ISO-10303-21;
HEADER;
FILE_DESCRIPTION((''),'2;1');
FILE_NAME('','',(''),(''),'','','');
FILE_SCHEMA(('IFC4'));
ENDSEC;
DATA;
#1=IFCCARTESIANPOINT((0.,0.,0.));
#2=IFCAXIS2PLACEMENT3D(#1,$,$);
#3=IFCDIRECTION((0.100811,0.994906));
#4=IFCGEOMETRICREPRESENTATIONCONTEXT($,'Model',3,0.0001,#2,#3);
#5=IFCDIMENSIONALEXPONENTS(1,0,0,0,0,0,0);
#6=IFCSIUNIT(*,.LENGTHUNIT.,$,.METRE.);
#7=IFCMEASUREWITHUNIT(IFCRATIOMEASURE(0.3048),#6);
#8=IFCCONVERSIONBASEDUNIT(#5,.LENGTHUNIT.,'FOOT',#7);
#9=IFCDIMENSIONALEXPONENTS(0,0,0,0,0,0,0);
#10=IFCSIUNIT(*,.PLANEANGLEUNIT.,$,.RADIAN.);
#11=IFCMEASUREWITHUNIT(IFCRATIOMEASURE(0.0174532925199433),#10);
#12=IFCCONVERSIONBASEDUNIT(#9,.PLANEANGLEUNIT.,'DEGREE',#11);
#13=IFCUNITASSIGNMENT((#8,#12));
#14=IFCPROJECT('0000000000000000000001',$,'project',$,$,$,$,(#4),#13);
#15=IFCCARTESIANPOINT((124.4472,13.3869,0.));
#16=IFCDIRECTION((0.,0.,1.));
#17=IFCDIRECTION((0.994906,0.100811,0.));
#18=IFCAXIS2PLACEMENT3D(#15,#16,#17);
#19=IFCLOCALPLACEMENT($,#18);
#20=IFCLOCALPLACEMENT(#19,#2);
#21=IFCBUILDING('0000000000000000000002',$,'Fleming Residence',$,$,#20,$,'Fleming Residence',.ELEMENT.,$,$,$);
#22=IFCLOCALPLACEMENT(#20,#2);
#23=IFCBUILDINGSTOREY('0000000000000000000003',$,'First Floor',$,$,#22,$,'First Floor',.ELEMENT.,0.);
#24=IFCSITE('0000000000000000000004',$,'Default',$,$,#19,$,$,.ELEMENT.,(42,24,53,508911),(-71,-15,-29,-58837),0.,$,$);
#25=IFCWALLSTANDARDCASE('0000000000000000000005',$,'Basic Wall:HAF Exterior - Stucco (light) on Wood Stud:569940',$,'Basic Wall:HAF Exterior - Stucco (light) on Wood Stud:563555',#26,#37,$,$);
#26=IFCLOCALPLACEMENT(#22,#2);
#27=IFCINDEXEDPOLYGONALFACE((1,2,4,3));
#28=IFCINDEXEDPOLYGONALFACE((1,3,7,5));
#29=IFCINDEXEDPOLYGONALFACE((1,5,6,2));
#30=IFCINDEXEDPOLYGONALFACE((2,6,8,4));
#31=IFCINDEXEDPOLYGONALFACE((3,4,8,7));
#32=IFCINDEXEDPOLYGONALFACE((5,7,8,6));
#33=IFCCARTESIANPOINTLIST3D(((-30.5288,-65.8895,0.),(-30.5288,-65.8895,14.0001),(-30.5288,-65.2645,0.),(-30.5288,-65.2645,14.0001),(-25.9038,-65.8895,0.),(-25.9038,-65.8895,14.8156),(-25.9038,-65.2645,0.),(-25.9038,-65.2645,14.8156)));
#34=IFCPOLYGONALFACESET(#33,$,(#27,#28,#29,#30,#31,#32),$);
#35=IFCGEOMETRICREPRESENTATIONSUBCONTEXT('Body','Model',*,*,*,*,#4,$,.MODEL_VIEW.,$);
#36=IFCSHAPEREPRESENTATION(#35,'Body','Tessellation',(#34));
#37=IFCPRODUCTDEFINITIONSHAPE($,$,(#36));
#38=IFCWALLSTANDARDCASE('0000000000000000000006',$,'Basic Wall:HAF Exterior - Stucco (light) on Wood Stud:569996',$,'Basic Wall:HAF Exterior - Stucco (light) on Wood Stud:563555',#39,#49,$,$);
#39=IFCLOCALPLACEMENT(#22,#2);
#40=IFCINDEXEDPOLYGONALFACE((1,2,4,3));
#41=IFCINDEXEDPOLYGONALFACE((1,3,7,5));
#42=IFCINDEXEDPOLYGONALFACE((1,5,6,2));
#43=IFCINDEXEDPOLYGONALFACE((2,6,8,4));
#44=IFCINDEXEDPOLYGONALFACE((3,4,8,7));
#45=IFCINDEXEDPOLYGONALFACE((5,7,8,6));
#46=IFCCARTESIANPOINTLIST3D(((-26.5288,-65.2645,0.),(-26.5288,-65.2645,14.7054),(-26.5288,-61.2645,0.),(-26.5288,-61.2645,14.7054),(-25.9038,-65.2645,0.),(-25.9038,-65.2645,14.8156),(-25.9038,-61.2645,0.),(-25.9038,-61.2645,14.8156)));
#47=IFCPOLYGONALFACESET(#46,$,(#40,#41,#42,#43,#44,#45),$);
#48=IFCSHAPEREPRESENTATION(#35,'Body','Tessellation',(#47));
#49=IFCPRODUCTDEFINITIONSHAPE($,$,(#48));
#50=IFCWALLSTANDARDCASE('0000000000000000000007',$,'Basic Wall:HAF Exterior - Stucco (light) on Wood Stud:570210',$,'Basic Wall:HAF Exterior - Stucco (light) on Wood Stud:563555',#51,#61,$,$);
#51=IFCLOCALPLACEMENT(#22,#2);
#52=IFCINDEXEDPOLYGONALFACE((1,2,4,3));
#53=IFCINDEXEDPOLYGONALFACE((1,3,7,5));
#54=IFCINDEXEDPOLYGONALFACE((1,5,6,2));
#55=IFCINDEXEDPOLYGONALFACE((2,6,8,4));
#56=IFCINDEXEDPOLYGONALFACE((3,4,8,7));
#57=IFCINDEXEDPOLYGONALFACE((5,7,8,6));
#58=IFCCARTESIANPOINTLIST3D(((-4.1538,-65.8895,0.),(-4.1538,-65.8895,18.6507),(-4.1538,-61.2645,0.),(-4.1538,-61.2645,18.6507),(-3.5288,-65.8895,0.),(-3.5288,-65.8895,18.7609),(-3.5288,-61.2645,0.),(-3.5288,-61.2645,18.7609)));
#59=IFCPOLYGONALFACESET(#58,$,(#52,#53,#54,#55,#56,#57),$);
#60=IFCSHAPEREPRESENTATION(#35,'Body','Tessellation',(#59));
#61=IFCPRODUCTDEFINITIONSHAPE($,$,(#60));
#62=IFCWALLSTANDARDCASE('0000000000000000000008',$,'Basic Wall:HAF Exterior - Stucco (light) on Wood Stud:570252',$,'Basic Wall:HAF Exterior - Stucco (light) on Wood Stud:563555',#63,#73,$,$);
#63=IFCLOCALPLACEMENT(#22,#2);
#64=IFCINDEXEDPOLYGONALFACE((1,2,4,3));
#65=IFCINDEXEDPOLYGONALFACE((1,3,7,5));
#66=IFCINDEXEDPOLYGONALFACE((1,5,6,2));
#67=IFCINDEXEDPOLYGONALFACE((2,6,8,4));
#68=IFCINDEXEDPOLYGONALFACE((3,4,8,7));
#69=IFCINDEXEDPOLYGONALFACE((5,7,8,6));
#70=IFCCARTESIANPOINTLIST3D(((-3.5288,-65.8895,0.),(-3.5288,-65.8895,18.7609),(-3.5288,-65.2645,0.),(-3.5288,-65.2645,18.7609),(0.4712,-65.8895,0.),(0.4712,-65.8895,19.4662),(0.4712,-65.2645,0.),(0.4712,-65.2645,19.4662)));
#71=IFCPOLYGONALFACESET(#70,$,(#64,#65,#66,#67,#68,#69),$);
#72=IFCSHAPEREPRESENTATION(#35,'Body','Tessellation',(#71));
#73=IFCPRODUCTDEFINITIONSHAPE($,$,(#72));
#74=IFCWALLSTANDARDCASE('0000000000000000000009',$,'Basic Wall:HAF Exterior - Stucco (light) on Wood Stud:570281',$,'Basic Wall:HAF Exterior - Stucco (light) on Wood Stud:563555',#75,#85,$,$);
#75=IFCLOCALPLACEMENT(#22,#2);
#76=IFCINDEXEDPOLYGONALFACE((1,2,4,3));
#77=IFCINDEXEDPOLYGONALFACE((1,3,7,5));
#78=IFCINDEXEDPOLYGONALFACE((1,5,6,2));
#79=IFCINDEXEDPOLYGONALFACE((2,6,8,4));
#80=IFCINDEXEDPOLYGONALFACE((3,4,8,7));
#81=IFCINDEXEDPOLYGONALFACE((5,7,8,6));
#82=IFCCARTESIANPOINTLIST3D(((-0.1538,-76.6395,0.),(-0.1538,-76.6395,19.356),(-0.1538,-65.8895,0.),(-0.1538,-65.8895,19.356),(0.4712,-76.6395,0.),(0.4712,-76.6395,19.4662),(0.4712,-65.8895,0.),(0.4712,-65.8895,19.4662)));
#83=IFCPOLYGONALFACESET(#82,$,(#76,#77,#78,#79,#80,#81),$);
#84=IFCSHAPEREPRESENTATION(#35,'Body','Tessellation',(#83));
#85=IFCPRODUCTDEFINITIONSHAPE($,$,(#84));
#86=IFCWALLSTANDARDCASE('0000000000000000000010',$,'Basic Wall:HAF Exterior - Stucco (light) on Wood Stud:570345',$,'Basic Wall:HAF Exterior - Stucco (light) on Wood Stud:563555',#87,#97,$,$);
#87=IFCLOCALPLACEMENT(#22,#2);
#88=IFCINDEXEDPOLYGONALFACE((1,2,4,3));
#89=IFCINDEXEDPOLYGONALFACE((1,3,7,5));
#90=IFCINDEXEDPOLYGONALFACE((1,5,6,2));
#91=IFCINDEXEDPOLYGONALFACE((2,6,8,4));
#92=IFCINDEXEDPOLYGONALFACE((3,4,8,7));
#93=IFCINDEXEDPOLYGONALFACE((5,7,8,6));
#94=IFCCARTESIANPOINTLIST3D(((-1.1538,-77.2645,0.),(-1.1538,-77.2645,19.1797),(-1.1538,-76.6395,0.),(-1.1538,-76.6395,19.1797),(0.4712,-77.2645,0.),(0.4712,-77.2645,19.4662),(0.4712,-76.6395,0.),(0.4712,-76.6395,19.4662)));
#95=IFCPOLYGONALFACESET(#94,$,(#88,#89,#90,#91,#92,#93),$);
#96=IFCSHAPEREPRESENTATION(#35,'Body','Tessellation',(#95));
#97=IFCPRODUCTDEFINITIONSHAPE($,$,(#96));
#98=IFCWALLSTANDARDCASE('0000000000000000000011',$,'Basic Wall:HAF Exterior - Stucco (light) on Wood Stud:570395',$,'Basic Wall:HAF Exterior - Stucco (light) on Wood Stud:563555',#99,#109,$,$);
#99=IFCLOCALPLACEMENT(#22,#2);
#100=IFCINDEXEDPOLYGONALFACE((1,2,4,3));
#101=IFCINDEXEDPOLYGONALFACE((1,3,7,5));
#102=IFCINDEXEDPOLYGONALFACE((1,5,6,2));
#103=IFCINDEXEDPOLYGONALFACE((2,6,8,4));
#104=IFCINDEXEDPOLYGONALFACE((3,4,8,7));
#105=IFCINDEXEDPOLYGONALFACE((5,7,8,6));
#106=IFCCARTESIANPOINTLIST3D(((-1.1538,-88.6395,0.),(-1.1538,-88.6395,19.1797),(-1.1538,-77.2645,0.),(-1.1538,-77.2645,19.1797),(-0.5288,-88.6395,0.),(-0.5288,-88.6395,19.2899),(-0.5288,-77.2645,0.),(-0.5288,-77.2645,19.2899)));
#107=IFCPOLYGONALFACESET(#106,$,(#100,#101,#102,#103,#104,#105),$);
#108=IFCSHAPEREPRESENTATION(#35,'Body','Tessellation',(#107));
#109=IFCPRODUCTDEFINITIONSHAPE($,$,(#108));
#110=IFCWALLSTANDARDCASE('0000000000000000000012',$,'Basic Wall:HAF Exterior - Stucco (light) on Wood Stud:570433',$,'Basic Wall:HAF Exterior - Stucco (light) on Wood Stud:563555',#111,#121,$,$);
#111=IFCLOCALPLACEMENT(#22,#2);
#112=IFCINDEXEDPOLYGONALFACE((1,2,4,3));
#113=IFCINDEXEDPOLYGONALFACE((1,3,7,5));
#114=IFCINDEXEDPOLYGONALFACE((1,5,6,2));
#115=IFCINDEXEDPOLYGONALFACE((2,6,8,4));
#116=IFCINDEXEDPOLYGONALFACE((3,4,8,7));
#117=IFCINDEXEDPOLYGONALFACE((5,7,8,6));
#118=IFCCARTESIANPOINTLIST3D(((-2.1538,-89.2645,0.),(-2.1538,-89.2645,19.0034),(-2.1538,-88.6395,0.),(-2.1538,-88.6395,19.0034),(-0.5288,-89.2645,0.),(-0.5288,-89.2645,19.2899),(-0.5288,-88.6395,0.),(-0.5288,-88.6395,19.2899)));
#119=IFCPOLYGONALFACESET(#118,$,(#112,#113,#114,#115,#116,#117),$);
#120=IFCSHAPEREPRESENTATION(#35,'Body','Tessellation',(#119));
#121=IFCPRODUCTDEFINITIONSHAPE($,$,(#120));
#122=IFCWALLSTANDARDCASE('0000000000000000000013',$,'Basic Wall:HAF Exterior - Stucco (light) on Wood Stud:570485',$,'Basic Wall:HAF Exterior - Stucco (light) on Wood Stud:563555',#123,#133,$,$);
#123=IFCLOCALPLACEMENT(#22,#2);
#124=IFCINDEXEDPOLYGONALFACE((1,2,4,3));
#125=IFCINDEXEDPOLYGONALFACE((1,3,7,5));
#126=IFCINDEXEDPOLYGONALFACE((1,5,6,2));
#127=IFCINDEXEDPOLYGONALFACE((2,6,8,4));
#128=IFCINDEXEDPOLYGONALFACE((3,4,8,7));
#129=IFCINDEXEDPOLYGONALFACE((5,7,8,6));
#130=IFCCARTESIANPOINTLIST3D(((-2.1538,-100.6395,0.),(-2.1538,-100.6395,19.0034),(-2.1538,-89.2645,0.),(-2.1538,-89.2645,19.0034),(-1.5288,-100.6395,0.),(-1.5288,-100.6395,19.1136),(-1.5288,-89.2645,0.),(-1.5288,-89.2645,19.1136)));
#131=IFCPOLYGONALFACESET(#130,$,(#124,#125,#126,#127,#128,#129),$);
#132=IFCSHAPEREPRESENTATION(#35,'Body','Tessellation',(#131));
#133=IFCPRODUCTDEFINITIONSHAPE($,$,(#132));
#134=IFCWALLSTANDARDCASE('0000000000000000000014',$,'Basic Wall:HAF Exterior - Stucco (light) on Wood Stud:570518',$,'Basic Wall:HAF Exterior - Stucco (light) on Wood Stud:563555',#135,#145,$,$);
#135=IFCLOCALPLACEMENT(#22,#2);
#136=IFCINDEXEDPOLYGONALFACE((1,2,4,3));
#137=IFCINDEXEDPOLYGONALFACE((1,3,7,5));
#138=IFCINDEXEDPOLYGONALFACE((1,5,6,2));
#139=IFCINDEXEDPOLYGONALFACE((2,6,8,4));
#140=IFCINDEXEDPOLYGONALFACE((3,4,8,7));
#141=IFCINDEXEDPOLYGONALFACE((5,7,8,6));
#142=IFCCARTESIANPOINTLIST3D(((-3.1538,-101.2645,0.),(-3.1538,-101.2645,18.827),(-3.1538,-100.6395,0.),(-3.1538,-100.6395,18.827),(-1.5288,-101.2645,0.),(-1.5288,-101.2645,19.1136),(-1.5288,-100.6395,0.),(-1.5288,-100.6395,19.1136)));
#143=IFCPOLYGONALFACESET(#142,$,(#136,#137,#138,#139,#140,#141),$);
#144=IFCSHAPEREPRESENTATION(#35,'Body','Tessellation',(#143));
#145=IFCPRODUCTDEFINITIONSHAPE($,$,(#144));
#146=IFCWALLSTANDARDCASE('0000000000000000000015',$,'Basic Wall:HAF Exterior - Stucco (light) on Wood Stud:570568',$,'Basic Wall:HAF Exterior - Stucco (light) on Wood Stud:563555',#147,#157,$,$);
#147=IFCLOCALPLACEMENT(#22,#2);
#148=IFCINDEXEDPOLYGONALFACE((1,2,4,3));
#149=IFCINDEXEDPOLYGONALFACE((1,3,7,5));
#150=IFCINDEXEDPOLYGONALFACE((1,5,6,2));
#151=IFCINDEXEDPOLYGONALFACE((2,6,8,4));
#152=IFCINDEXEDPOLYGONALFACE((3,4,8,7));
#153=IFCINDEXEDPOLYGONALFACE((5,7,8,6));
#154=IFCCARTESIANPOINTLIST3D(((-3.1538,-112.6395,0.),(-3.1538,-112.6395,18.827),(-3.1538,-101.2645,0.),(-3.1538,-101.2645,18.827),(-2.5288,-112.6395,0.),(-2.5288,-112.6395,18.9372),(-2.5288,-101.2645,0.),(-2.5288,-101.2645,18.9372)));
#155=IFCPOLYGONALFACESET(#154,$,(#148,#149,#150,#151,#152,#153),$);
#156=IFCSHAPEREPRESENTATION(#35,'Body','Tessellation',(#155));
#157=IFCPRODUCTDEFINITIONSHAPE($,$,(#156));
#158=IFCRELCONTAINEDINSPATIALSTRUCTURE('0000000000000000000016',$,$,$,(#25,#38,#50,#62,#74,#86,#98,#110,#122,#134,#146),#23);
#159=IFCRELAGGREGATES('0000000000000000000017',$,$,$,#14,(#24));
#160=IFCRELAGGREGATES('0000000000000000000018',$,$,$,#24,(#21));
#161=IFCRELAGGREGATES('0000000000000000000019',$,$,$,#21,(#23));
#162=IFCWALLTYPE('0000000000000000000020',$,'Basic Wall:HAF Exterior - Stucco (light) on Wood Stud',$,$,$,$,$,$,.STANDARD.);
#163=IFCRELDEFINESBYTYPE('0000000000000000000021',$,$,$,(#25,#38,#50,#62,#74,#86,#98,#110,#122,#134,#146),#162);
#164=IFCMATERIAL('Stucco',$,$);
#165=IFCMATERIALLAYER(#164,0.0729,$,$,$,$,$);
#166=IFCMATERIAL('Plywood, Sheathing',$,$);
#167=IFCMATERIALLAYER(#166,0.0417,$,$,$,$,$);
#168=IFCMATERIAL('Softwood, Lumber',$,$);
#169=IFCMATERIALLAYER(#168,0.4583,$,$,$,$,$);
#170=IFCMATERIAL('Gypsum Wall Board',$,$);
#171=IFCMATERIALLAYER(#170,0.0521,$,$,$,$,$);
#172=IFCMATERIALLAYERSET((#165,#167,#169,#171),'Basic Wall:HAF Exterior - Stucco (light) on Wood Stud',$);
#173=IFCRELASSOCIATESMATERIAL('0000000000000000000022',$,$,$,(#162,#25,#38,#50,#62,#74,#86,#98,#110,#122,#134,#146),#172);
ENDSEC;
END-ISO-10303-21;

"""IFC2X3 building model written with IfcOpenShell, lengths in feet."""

from ifc_helpers import new_model, entity, si_unit, converted_unit, direction, frame, frame_2d, origin, place, context, subcontext, project, spatial, polyline, rectangle, extrude, clip, bounded_halfspace, material, layer, layer_set, layer_usage, type_object, element, save


model = new_model("IFC2X3")

# Units and contexts
model_context = context("Model", 3, precision=0.0001, world=origin(), true_north=direction((0.100811, 0.994906)))
body_context = subcontext(model_context, "Body", "Model", "MODEL_VIEW")
ifc_project = project(units=[converted_unit("LENGTHUNIT", "FOOT", entity("IfcRatioMeasure", 0.3048), si_unit("LENGTHUNIT", "METRE"), dimensions=[1, 0, 0, 0, 0, 0, 0]), converted_unit("PLANEANGLEUNIT", "DEGREE", entity("IfcRatioMeasure", 0.0174532925199433), si_unit("PLANEANGLEUNIT", "RADIAN"), dimensions=[0, 0, 0, 0, 0, 0, 0])], contexts=[model_context])

# Site, building, storey
site_placement = place(None, frame((124.4472, 13.3869, 0.0), z_axis=(0.0, 0.0, 1.0), x_axis=(0.994906, 0.100811, 0.0)))
site = spatial("IfcSite", under=ifc_project, at=site_placement, Name="Default", CompositionType="ELEMENT", RefLatitude=(42, 24, 53, 508911), RefLongitude=(-71, -15, -29, -58837), RefElevation=0.0)
building_placement = place(site_placement, origin())
building = spatial("IfcBuilding", under=site, at=building_placement, Name="Fleming Residence", LongName="Fleming Residence", CompositionType="ELEMENT")
storey_placement = place(building_placement, origin())
storey = spatial("IfcBuildingStorey", under=building, at=storey_placement, Name="First Floor", LongName="First Floor", CompositionType="ELEMENT", Elevation=0.0)

# Walls
ifc_material_1 = material(Name="Stucco")
ifc_layer_1 = layer(ifc_material_1, 0.0729)
ifc_material_2 = material(Name="Plywood, Sheathing")
ifc_layer_2 = layer(ifc_material_2, 0.0417)
ifc_material_3 = material(Name="Softwood, Lumber")
ifc_layer_3 = layer(ifc_material_3, 0.4583)
ifc_material_4 = material(Name="Gypsum Wall Board")
ifc_layer_4 = layer(ifc_material_4, 0.0521)
ifc_layer_set_1 = layer_set([ifc_layer_1, ifc_layer_2, ifc_layer_3, ifc_layer_4], Name="Basic Wall:HAF Exterior - Stucco (light) on Wood Stud")
ifc_layer_usage_1 = layer_usage(ifc_layer_set_1, "AXIS2", "NEGATIVE", 0.3125)
wall_type_1 = type_object("IfcWallType", Name="Basic Wall:HAF Exterior - Stucco (light) on Wood Stud", PredefinedType="STANDARD", material=ifc_layer_set_1)
wall_1_placement = place(storey_placement, frame((-30.5288, -65.577, 0.0)))
element("IfcWallStandardCase", 1, at=wall_1_placement, inside=storey, type_object=wall_type_1, material=ifc_layer_usage_1, Name="Basic Wall:HAF Exterior - Stucco (light) on Wood Stud:569940", ObjectType="Basic Wall:HAF Exterior - Stucco (light) on Wood Stud:563555", context=body_context, shape_type="Clipping", body=[
    clip(extrude(rectangle(XDim=4.625, YDim=0.625, at=frame_2d((2.3125, 0.0), x_axis=(-1.0, 0.0))), origin(), (0.0, 0.0, 1.0), 14.8156), bounded_halfspace(frame((0.0, -0.3125, 14.0001), z_axis=(0.173648, 0.0, -0.984808), x_axis=(0.0, -1.0, 0.0)), True, frame((0.0, -0.3125, 14.0001)), polyline([(0.0, 0.0), (0.625, 0.0), (4.625, 0.0), (4.625, 0.625), (4.0, 0.625), (0.0, 0.625), (0.0, 0.0)]))),
])
ifc_layer_usage_2 = layer_usage(ifc_layer_set_1, "AXIS2", "NEGATIVE", 0.3125)
wall_2_placement = place(storey_placement, frame((-26.2163, -65.2645, 0.0), z_axis=(0.0, 0.0, 1.0), x_axis=(0.0, 1.0, 0.0)))
element("IfcWallStandardCase", 2, at=wall_2_placement, inside=storey, type_object=wall_type_1, material=ifc_layer_usage_2, Name="Basic Wall:HAF Exterior - Stucco (light) on Wood Stud:569996", ObjectType="Basic Wall:HAF Exterior - Stucco (light) on Wood Stud:563555", context=body_context, shape_type="Clipping", body=[
    clip(extrude(rectangle(XDim=4.0, YDim=0.625, at=frame_2d((2.0, 0.0), x_axis=(-1.0, 0.0))), origin(), (0.0, 0.0, 1.0), 14.8156), bounded_halfspace(frame((0.0, -0.3125, 14.8156), z_axis=(0.0, -0.173648, -0.984808), x_axis=(-1.0, 0.0, 0.0)), True, frame((0.0, -0.3125, 14.8156)), polyline([(0.0, 0.0), (3.375, 0.0), (4.0, 0.0), (4.0, 0.625), (0.0, 0.625), (0.0, 0.0)]))),
])
ifc_layer_usage_3 = layer_usage(ifc_layer_set_1, "AXIS2", "NEGATIVE", 0.3125)
wall_3_placement = place(storey_placement, frame((-3.8413, -61.2645, 0.0), z_axis=(0.0, 0.0, 1.0), x_axis=(0.0, -1.0, 0.0)))
element("IfcWallStandardCase", 3, at=wall_3_placement, inside=storey, type_object=wall_type_1, material=ifc_layer_usage_3, Name="Basic Wall:HAF Exterior - Stucco (light) on Wood Stud:570210", ObjectType="Basic Wall:HAF Exterior - Stucco (light) on Wood Stud:563555", context=body_context, shape_type="Clipping", body=[
    clip(extrude(rectangle(XDim=4.625, YDim=0.625, at=frame_2d((2.3125, 0.0), x_axis=(-1.0, 0.0))), origin(), (0.0, 0.0, 1.0), 18.7609), bounded_halfspace(frame((0.0, -0.3125, 18.6507), z_axis=(0.0, 0.173648, -0.984808), x_axis=(1.0, 0.0, 0.0)), True, frame((0.0, -0.3125, 18.6507)), polyline([(0.0, 0.0), (0.625, 0.0), (4.625, 0.0), (4.625, 0.625), (4.0, 0.625), (0.0, 0.625), (0.0, 0.0)]))),
])
ifc_layer_usage_4 = layer_usage(ifc_layer_set_1, "AXIS2", "NEGATIVE", 0.3125)
wall_4_placement = place(storey_placement, frame((-3.5288, -65.577, 0.0)))
element("IfcWallStandardCase", 4, at=wall_4_placement, inside=storey, type_object=wall_type_1, material=ifc_layer_usage_4, Name="Basic Wall:HAF Exterior - Stucco (light) on Wood Stud:570252", ObjectType="Basic Wall:HAF Exterior - Stucco (light) on Wood Stud:563555", context=body_context, shape_type="Clipping", body=[
    clip(extrude(rectangle(XDim=4.0, YDim=0.625, at=frame_2d((2.0, 0.0), x_axis=(-1.0, 0.0))), origin(), (0.0, 0.0, 1.0), 19.4662), bounded_halfspace(frame((0.0, -0.3125, 18.7609), z_axis=(0.173648, 0.0, -0.984808), x_axis=(0.0, -1.0, 0.0)), True, frame((0.0, -0.3125, 18.7609)), polyline([(0.0, 0.0), (3.375, 0.0), (4.0, 0.0), (4.0, 0.625), (0.0, 0.625), (0.0, 0.0)]))),
])
ifc_layer_usage_5 = layer_usage(ifc_layer_set_1, "AXIS2", "NEGATIVE", 0.3125)
wall_5_placement = place(storey_placement, frame((0.1587, -65.8895, 0.0), z_axis=(0.0, 0.0, 1.0), x_axis=(0.0, -1.0, 0.0)))
element("IfcWallStandardCase", 5, at=wall_5_placement, inside=storey, type_object=wall_type_1, material=ifc_layer_usage_5, Name="Basic Wall:HAF Exterior - Stucco (light) on Wood Stud:570281", ObjectType="Basic Wall:HAF Exterior - Stucco (light) on Wood Stud:563555", context=body_context, shape_type="Clipping", body=[
    clip(extrude(rectangle(XDim=10.75, YDim=0.625, at=frame_2d((5.375, 0.0), x_axis=(-1.0, 0.0))), origin(), (0.0, 0.0, 1.0), 19.4662), bounded_halfspace(frame((0.0, -0.3125, 19.356), z_axis=(0.0, 0.173648, -0.984808), x_axis=(1.0, 0.0, 0.0)), True, frame((0.0, -0.3125, 19.356)), polyline([(0.0, 0.0), (10.75, 0.0), (10.75, 0.625), (0.0, 0.625), (0.0, 0.0)]))),
])
ifc_layer_usage_6 = layer_usage(ifc_layer_set_1, "AXIS2", "NEGATIVE", 0.3125)
wall_6_placement = place(storey_placement, frame((0.4712, -76.952, 0.0), z_axis=(0.0, 0.0, 1.0), x_axis=(-1.0, 0.0, 0.0)))
element("IfcWallStandardCase", 6, at=wall_6_placement, inside=storey, type_object=wall_type_1, material=ifc_layer_usage_6, Name="Basic Wall:HAF Exterior - Stucco (light) on Wood Stud:570345", ObjectType="Basic Wall:HAF Exterior - Stucco (light) on Wood Stud:563555", context=body_context, shape_type="Clipping", body=[
    clip(extrude(rectangle(XDim=1.625, YDim=0.625, at=frame_2d((0.8125, 0.0), x_axis=(-1.0, 0.0))), origin(), (0.0, 0.0, 1.0), 19.4662), bounded_halfspace(frame((0.0, -0.3125, 19.4662), z_axis=(-0.173648, 0.0, -0.984808), x_axis=(0.0, 1.0, 0.0)), True, frame((0.0, -0.3125, 19.4662)), polyline([(0.0, 0.0), (0.625, 0.0), (1.625, 0.0), (1.625, 0.625), (1.0, 0.625), (0.0, 0.625), (0.0, 0.0)]))),
])
ifc_layer_usage_7 = layer_usage(ifc_layer_set_1, "AXIS2", "NEGATIVE", 0.3125)
wall_7_placement = place(storey_placement, frame((-0.8413, -77.2645, 0.0), z_axis=(0.0, 0.0, 1.0), x_axis=(0.0, -1.0, 0.0)))
element("IfcWallStandardCase", 7, at=wall_7_placement, inside=storey, type_object=wall_type_1, material=ifc_layer_usage_7, Name="Basic Wall:HAF Exterior - Stucco (light) on Wood Stud:570395", ObjectType="Basic Wall:HAF Exterior - Stucco (light) on Wood Stud:563555", context=body_context, shape_type="Clipping", body=[
    clip(extrude(rectangle(XDim=11.375, YDim=0.625, at=frame_2d((5.6875, 0.0), x_axis=(-1.0, 0.0))), origin(), (0.0, 0.0, 1.0), 19.2899), bounded_halfspace(frame((0.0, -0.3125, 19.1797), z_axis=(0.0, 0.173648, -0.984808), x_axis=(1.0, 0.0, 0.0)), True, frame((0.0, -0.3125, 19.1797)), polyline([(0.0, 0.0), (11.375, 0.0), (11.375, 0.625), (0.0, 0.625), (0.0, 0.0)]))),
])
ifc_layer_usage_8 = layer_usage(ifc_layer_set_1, "AXIS2", "NEGATIVE", 0.3125)
wall_8_placement = place(storey_placement, frame((-0.5288, -88.952, 0.0), z_axis=(0.0, 0.0, 1.0), x_axis=(-1.0, 0.0, 0.0)))
element("IfcWallStandardCase", 8, at=wall_8_placement, inside=storey, type_object=wall_type_1, material=ifc_layer_usage_8, Name="Basic Wall:HAF Exterior - Stucco (light) on Wood Stud:570433", ObjectType="Basic Wall:HAF Exterior - Stucco (light) on Wood Stud:563555", context=body_context, shape_type="Clipping", body=[
    clip(extrude(rectangle(XDim=1.625, YDim=0.625, at=frame_2d((0.8125, 0.0), x_axis=(-1.0, 0.0))), origin(), (0.0, 0.0, 1.0), 19.2899), bounded_halfspace(frame((0.0, -0.3125, 19.2899), z_axis=(-0.173648, 0.0, -0.984808), x_axis=(0.0, 1.0, 0.0)), True, frame((0.0, -0.3125, 19.2899)), polyline([(0.0, 0.0), (0.625, 0.0), (1.625, 0.0), (1.625, 0.625), (1.0, 0.625), (0.0, 0.625), (0.0, 0.0)]))),
])
ifc_layer_usage_9 = layer_usage(ifc_layer_set_1, "AXIS2", "NEGATIVE", 0.3125)
wall_9_placement = place(storey_placement, frame((-1.8413, -89.2645, 0.0), z_axis=(0.0, 0.0, 1.0), x_axis=(0.0, -1.0, 0.0)))
element("IfcWallStandardCase", 9, at=wall_9_placement, inside=storey, type_object=wall_type_1, material=ifc_layer_usage_9, Name="Basic Wall:HAF Exterior - Stucco (light) on Wood Stud:570485", ObjectType="Basic Wall:HAF Exterior - Stucco (light) on Wood Stud:563555", context=body_context, shape_type="Clipping", body=[
    clip(extrude(rectangle(XDim=11.375, YDim=0.625, at=frame_2d((5.6875, 0.0), x_axis=(-1.0, 0.0))), origin(), (0.0, 0.0, 1.0), 19.1136), bounded_halfspace(frame((0.0, -0.3125, 19.0034), z_axis=(0.0, 0.173648, -0.984808), x_axis=(1.0, 0.0, 0.0)), True, frame((0.0, -0.3125, 19.0034)), polyline([(0.0, 0.0), (11.375, 0.0), (11.375, 0.625), (0.0, 0.625), (0.0, 0.0)]))),
])
ifc_layer_usage_10 = layer_usage(ifc_layer_set_1, "AXIS2", "NEGATIVE", 0.3125)
wall_10_placement = place(storey_placement, frame((-1.5288, -100.952, 0.0), z_axis=(0.0, 0.0, 1.0), x_axis=(-1.0, 0.0, 0.0)))
element("IfcWallStandardCase", 10, at=wall_10_placement, inside=storey, type_object=wall_type_1, material=ifc_layer_usage_10, Name="Basic Wall:HAF Exterior - Stucco (light) on Wood Stud:570518", ObjectType="Basic Wall:HAF Exterior - Stucco (light) on Wood Stud:563555", context=body_context, shape_type="Clipping", body=[
    clip(extrude(rectangle(XDim=1.625, YDim=0.625, at=frame_2d((0.8125, 0.0), x_axis=(-1.0, 0.0))), origin(), (0.0, 0.0, 1.0), 19.1136), bounded_halfspace(frame((0.0, -0.3125, 19.1136), z_axis=(-0.173648, 0.0, -0.984808), x_axis=(0.0, 1.0, 0.0)), True, frame((0.0, -0.3125, 19.1136)), polyline([(0.0, 0.0), (0.625, 0.0), (1.625, 0.0), (1.625, 0.625), (1.0, 0.625), (0.0, 0.625), (0.0, 0.0)]))),
])
ifc_layer_usage_11 = layer_usage(ifc_layer_set_1, "AXIS2", "NEGATIVE", 0.3125)
wall_11_placement = place(storey_placement, frame((-2.8413, -101.2645, 0.0), z_axis=(0.0, 0.0, 1.0), x_axis=(0.0, -1.0, 0.0)))
element("IfcWallStandardCase", 11, at=wall_11_placement, inside=storey, type_object=wall_type_1, material=ifc_layer_usage_11, Name="Basic Wall:HAF Exterior - Stucco (light) on Wood Stud:570568", ObjectType="Basic Wall:HAF Exterior - Stucco (light) on Wood Stud:563555", context=body_context, shape_type="Clipping", body=[
    clip(extrude(rectangle(XDim=11.375, YDim=0.625, at=frame_2d((5.6875, 0.0), x_axis=(-1.0, 0.0))), origin(), (0.0, 0.0, 1.0), 18.9372), bounded_halfspace(frame((0.0, -0.3125, 18.827), z_axis=(0.0, 0.173648, -0.984808), x_axis=(1.0, 0.0, 0.0)), True, frame((0.0, -0.3125, 18.827)), polyline([(0.0, 0.0), (11.375, 0.0), (11.375, 0.625), (0.0, 0.625), (0.0, 0.0)]))),
])

save(model, "model.ifc")
